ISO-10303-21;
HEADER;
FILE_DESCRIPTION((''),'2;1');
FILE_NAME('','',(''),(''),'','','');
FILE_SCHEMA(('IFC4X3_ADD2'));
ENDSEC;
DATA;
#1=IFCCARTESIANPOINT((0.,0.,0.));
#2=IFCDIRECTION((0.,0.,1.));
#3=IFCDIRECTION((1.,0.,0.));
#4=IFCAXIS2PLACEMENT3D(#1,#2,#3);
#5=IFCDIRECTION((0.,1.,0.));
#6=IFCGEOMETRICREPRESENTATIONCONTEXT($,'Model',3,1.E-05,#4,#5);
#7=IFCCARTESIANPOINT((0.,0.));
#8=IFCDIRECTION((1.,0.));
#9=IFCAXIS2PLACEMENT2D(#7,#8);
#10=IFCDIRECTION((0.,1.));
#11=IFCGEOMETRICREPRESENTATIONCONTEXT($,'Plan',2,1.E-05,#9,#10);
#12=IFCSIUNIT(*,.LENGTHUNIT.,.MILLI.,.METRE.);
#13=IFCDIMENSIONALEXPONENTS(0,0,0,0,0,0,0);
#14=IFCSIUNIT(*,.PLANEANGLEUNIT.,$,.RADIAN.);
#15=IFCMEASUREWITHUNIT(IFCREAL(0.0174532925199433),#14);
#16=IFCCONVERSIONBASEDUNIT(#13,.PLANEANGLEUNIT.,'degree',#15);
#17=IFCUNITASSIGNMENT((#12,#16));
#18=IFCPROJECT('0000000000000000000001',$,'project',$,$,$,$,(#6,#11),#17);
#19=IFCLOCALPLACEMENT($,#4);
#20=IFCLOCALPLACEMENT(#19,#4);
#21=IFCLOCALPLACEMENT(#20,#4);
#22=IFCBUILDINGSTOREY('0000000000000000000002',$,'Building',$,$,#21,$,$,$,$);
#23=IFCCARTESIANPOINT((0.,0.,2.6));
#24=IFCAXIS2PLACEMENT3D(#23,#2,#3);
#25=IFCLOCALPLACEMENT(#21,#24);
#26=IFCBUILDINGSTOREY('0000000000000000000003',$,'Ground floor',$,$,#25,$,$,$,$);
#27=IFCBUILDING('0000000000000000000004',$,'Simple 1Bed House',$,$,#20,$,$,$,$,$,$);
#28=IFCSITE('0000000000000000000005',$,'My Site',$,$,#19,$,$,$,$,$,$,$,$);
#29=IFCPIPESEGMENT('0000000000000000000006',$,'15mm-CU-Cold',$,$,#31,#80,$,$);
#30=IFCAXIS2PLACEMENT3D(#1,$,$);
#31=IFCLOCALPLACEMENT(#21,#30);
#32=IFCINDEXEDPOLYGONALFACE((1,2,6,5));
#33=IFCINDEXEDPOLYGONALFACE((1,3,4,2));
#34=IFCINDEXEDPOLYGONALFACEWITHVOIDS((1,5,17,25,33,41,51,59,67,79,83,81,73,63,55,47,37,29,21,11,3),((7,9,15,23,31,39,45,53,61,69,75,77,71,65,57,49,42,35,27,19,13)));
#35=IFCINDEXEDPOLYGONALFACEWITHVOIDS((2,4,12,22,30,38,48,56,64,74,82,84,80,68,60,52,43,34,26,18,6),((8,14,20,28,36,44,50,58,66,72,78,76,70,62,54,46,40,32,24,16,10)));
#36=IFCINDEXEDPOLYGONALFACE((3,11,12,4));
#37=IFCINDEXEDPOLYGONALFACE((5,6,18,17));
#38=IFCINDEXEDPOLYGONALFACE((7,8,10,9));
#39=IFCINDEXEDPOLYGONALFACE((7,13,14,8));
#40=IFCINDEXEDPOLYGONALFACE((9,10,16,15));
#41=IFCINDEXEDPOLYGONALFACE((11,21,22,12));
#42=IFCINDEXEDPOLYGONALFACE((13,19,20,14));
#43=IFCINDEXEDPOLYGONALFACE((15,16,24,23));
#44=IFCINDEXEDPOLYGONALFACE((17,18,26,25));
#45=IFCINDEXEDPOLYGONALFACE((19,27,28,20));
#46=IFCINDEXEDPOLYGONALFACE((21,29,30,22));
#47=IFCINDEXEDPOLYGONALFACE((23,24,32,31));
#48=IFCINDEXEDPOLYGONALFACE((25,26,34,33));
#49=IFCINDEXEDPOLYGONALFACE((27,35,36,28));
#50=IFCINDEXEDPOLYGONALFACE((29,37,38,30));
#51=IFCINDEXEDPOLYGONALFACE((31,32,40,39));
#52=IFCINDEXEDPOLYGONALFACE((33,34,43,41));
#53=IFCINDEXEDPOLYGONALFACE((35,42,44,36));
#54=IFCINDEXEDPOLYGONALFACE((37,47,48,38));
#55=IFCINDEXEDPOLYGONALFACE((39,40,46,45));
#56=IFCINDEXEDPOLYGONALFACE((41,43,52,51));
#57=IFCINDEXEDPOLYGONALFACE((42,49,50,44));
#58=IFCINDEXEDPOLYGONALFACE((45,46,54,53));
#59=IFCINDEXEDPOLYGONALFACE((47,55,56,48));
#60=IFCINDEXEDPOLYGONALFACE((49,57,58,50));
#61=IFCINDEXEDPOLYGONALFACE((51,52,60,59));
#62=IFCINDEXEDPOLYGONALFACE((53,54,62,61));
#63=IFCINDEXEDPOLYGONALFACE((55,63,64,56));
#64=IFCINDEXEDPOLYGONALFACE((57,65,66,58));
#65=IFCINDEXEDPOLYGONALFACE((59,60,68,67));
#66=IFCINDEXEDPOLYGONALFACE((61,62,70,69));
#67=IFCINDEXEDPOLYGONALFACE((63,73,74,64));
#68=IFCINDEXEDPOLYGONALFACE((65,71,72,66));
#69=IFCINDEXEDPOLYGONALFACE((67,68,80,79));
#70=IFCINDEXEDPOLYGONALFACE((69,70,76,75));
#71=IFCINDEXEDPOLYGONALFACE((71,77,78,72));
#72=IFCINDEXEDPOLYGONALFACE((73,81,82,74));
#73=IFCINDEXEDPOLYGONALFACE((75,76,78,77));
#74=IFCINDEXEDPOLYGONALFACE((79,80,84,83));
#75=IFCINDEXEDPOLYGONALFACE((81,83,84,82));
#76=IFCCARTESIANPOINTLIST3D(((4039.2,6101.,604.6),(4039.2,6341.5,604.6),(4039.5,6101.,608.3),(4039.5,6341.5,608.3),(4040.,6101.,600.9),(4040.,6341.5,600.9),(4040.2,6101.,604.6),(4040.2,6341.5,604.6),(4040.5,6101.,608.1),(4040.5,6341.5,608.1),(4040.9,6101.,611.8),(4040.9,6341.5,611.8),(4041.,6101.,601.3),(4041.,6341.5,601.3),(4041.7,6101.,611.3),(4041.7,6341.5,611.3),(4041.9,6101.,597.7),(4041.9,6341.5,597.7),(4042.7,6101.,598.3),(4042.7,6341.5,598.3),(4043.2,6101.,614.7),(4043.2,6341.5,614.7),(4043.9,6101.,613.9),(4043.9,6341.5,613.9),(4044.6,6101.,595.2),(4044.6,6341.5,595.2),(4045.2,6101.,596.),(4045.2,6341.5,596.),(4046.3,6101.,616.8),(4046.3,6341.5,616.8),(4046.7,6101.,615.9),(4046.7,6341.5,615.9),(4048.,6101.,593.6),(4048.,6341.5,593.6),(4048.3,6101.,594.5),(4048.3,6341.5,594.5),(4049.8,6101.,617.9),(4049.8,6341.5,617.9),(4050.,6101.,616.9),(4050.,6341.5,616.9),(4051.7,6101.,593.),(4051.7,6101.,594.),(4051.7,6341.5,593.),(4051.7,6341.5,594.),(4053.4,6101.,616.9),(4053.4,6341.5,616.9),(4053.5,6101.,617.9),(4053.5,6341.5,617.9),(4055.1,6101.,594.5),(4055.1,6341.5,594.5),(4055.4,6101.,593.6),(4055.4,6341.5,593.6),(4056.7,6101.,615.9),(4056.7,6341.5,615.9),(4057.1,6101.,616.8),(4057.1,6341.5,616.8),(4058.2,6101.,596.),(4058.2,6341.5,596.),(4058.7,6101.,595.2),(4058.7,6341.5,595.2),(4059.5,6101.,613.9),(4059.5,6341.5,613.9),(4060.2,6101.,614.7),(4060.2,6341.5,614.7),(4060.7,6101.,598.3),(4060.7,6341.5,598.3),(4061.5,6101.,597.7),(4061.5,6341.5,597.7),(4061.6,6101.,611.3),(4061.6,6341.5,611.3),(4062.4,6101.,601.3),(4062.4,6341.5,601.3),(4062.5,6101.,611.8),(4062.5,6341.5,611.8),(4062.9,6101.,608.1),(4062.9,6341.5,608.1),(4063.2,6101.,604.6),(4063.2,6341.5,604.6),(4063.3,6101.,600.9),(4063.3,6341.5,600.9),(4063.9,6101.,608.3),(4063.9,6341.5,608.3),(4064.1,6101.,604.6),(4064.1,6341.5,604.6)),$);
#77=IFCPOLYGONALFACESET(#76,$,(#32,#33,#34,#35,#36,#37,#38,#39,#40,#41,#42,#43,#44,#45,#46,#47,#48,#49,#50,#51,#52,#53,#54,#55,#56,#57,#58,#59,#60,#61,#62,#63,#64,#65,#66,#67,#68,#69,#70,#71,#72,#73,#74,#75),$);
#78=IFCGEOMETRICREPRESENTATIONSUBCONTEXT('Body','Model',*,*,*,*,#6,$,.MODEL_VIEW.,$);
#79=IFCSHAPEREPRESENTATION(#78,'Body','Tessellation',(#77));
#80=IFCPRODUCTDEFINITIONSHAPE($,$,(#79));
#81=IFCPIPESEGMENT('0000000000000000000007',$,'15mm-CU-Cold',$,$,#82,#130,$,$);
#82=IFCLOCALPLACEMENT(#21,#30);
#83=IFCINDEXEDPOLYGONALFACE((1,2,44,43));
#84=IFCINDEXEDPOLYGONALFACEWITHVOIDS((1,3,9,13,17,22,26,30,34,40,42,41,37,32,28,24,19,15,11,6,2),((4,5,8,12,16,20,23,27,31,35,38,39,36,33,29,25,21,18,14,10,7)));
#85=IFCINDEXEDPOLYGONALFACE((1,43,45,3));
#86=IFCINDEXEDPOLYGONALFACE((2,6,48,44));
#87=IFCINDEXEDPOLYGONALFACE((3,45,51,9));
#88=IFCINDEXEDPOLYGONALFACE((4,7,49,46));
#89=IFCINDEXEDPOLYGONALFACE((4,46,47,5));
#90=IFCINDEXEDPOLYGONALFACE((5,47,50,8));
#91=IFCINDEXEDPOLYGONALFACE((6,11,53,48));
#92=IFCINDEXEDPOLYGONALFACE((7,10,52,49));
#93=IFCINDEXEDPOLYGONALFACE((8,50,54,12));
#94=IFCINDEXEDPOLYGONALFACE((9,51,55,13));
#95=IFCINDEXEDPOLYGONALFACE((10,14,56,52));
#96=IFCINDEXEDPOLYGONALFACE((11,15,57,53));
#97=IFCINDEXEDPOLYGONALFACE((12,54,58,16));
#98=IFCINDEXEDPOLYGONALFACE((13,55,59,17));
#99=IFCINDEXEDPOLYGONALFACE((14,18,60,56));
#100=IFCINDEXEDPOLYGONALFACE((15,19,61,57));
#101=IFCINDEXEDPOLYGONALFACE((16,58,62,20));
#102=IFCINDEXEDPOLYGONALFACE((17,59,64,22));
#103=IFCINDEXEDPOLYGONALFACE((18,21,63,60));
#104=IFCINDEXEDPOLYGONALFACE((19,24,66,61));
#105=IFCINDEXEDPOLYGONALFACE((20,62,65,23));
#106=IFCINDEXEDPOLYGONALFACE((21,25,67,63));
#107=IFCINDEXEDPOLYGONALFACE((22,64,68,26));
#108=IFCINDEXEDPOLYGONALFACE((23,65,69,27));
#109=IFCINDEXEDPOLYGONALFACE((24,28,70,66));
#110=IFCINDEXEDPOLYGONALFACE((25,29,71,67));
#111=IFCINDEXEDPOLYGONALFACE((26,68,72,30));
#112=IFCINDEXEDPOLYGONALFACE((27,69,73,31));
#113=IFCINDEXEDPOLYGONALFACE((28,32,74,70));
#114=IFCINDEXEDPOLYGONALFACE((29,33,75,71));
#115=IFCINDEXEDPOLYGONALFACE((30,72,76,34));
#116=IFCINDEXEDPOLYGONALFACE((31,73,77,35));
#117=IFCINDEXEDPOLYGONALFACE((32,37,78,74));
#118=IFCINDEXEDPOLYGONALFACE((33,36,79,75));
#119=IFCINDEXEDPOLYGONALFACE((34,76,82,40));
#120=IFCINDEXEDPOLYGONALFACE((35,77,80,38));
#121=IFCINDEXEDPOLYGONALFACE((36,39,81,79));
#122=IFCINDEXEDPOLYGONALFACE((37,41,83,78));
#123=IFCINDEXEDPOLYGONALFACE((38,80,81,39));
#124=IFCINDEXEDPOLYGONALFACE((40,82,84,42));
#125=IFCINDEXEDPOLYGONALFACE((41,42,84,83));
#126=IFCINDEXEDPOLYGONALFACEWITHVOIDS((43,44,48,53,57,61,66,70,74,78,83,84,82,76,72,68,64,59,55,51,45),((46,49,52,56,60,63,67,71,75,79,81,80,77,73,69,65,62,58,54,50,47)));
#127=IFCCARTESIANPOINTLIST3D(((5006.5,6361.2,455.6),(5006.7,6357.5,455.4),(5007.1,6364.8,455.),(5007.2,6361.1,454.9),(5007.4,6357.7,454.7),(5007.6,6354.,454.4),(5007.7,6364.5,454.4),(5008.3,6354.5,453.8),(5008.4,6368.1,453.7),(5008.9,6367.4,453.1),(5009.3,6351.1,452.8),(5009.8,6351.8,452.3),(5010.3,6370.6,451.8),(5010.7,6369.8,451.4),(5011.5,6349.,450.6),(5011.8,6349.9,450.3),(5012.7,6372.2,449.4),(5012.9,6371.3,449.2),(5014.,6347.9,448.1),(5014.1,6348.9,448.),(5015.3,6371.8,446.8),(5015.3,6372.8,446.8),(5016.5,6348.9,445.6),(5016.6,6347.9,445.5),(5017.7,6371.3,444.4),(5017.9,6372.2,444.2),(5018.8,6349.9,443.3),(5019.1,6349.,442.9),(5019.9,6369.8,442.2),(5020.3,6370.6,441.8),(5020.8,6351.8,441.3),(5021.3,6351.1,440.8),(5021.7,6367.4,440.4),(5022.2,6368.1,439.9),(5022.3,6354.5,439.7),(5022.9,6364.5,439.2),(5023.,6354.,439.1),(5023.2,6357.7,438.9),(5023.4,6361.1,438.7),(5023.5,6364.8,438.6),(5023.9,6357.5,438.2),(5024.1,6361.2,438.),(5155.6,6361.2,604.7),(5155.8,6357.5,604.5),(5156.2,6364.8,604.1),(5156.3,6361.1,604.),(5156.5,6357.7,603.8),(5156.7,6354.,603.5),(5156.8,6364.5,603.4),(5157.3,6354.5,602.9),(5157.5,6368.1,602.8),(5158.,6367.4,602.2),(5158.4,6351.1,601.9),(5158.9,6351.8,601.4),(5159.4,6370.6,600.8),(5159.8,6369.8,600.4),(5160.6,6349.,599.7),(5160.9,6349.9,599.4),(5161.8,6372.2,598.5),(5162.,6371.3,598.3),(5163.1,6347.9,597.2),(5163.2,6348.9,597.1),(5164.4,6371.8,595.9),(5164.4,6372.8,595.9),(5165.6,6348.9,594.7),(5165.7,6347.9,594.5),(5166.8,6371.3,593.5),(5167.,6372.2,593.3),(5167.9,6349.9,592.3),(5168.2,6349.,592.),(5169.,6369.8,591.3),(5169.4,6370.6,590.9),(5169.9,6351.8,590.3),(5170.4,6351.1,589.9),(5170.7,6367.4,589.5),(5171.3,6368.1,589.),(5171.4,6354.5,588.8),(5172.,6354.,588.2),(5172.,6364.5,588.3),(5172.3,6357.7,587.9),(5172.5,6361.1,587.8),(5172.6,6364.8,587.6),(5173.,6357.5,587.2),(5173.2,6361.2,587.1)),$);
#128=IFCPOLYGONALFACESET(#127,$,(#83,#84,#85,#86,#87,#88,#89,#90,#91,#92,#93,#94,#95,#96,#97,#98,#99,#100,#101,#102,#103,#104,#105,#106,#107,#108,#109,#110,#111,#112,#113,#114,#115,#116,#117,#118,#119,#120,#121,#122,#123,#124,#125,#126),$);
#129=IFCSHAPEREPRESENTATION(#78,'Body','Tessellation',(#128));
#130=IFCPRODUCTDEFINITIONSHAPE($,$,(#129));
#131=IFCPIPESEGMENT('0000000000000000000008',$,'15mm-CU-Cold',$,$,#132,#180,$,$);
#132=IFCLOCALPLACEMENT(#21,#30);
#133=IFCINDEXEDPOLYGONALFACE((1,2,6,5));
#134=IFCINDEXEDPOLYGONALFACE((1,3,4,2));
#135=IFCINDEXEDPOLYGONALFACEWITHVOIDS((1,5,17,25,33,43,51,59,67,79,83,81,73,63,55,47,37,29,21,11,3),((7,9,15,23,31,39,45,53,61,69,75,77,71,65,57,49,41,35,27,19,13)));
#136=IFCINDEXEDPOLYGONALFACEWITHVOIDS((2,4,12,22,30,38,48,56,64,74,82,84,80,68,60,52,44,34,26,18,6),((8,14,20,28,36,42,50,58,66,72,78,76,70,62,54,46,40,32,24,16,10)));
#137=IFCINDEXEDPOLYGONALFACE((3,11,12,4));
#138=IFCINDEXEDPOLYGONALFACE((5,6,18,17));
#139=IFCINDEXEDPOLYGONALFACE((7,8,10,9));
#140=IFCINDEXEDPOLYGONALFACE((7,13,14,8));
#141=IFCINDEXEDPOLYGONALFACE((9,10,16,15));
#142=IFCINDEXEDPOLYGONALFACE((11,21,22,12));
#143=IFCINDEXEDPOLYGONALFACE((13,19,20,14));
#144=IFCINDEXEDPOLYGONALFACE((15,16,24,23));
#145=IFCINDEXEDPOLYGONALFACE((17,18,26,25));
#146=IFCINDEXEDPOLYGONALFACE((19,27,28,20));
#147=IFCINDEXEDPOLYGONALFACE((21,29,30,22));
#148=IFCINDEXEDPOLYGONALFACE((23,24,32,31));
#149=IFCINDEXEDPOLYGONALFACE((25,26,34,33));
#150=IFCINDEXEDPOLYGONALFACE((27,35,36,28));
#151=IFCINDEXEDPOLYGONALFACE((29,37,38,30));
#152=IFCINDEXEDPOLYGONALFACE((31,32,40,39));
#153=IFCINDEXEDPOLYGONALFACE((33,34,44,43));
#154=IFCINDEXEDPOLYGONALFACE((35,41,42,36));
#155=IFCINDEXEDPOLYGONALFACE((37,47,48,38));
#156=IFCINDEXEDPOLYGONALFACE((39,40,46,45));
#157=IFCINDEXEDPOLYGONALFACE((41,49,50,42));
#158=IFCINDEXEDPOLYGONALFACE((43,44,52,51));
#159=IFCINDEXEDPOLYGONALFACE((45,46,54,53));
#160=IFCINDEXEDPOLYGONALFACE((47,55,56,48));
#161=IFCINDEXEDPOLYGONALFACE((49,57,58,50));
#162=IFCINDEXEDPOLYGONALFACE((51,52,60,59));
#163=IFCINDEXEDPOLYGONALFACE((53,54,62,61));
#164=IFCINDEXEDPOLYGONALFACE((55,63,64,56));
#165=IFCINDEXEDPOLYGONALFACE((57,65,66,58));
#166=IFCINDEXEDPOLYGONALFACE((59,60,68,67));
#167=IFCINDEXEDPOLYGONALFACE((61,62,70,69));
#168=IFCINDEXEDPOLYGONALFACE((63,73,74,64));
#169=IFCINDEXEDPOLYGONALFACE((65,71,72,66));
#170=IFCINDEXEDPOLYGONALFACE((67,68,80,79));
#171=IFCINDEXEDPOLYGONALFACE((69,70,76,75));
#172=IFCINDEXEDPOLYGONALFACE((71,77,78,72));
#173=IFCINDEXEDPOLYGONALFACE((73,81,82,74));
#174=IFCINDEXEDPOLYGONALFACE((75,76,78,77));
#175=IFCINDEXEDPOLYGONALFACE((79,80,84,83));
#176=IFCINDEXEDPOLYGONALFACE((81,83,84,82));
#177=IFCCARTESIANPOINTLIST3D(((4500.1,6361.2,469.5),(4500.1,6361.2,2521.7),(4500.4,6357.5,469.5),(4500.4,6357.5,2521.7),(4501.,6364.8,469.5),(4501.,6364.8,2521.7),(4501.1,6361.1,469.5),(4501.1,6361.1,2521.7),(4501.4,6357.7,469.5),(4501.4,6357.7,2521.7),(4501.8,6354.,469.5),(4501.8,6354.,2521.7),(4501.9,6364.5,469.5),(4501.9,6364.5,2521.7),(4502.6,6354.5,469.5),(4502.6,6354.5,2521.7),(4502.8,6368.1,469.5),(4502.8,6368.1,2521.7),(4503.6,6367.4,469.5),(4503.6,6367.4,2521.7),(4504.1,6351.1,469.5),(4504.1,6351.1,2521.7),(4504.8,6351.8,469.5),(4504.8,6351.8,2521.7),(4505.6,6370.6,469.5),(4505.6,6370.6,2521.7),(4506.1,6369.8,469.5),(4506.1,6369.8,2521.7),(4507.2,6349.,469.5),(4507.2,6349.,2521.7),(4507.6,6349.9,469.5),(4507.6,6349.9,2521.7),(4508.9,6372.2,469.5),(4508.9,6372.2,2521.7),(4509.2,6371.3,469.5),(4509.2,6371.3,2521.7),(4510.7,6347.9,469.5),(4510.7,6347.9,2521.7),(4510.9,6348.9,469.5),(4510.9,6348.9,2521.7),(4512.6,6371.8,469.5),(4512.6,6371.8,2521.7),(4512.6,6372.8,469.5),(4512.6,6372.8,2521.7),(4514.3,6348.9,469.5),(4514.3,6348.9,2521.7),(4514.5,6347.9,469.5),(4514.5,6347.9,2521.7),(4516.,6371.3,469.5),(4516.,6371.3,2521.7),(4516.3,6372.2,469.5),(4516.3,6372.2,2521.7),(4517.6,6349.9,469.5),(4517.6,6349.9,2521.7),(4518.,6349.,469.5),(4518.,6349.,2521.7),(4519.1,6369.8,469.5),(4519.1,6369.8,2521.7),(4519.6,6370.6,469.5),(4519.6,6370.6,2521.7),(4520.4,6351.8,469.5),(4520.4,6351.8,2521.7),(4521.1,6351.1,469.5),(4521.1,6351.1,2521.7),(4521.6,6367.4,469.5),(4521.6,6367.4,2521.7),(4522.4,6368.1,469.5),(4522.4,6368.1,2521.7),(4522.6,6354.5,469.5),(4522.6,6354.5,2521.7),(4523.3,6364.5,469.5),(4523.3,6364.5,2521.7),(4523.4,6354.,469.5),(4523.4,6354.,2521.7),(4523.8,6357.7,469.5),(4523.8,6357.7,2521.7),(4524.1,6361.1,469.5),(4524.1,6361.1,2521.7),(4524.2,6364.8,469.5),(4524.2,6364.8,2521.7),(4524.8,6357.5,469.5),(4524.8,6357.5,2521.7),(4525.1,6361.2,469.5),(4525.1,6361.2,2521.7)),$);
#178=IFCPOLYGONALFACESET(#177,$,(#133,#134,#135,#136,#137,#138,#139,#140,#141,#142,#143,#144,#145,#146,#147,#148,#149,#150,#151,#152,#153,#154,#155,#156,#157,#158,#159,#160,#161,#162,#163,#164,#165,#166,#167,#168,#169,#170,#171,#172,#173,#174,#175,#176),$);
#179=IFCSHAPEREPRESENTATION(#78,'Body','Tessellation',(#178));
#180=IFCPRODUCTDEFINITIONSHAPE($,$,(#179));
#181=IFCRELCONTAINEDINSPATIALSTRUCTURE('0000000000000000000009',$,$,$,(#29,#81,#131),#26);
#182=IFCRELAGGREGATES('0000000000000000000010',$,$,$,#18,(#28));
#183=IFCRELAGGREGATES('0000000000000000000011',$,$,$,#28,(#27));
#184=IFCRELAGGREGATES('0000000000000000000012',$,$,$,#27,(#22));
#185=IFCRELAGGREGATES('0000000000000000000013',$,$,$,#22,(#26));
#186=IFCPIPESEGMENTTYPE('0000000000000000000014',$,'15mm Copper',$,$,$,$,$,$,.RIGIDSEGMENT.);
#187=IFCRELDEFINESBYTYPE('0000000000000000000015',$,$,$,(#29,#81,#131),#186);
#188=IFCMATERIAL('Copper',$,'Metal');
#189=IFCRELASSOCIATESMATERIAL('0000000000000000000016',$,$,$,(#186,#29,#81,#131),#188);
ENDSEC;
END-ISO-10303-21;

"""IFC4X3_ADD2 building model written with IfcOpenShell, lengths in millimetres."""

from ifc_helpers import new_model, entity, si_unit, converted_unit, direction, frame, origin_with_axes, origin_2d_with_axis, place, context, subcontext, project, spatial, hollow_circle, extrude, material, material_profile, profile_set, profile_usage, type_object, element, save


model = new_model("IFC4X3_ADD2")

# Units and contexts
model_context = context("Model", 3, precision=1e-05, world=origin_with_axes(), true_north=direction((0.0, 1.0, 0.0)))
plan_context = context("Plan", 2, precision=1e-05, world=origin_2d_with_axis(), true_north=direction((0.0, 1.0)))
body_context_1 = subcontext(model_context, "Body", "Model", "MODEL_VIEW")
ifc_project = project(units=[si_unit("LENGTHUNIT", "METRE", prefix="MILLI"), converted_unit("PLANEANGLEUNIT", "degree", entity("IfcReal", 0.0174532925199433), si_unit("PLANEANGLEUNIT", "RADIAN"), dimensions=[0, 0, 0, 0, 0, 0, 0])], contexts=[model_context, plan_context])

# Site, building, storeys
site_placement = place(None, origin_with_axes())
site = spatial("IfcSite", under=ifc_project, at=site_placement, Name="My Site")
building_placement = place(site_placement, origin_with_axes())
building = spatial("IfcBuilding", under=site, at=building_placement, Name="Simple 1Bed House")
storey_1_placement = place(building_placement, origin_with_axes())
storey_1 = spatial("IfcBuildingStorey", under=building, at=storey_1_placement, Name="Building")
storey_2_placement = place(storey_1_placement, frame((0.0, 0.0, 2.6), z_axis=(0.0, 0.0, 1.0), x_axis=(1.0, 0.0, 0.0)))
storey_2 = spatial("IfcBuildingStorey", under=storey_1, at=storey_2_placement, Name="Ground floor")

# Pipe segments
ifc_material_1 = material(Name="Copper", Category="Metal")
ifc_material_profile = material_profile(ifc_material_1, hollow_circle(Radius=12.5, WallThickness=1.0))
ifc_profile_set = profile_set([ifc_material_profile])
pipe_segment_type = type_object("IfcPipeSegmentType", Name="15mm Copper", PredefinedType="RIGIDSEGMENT", material=ifc_profile_set)
ifc_profile_usage_1 = profile_usage(ifc_profile_set, cardinal=5)
pipe_segment_1_placement = place(storey_2_placement, frame((4051.7, 6341.5, 602.9), z_axis=(0.0, -1.0, 0.0), x_axis=(0.0, 0.0, -1.0)))
element("IfcPipeSegment", 1, at=pipe_segment_1_placement, inside=storey_2, type_object=pipe_segment_type, material=ifc_profile_usage_1, Name="15mm-CU-Cold", context=body_context_1, shape_type="SweptSolid", body=[
    extrude(hollow_circle(Radius=12.5, WallThickness=1.0), origin_with_axes(), (0.0, 0.0, 1.0), 240.5),
])
ifc_profile_usage_2 = profile_usage(ifc_profile_set, cardinal=5)
pipe_segment_2_placement = place(storey_2_placement, frame((5164.4, 6360.3, 593.3), z_axis=(-0.707107, 0.0, -0.707107), x_axis=(0.0, 1.0, 0.0)))
element("IfcPipeSegment", 2, at=pipe_segment_2_placement, inside=storey_2, type_object=pipe_segment_type, material=ifc_profile_usage_2, Name="15mm-CU-Cold", context=body_context_1, shape_type="SweptSolid", body=[
    extrude(hollow_circle(Radius=12.5, WallThickness=1.0), origin_with_axes(), (0.0, 0.0, 1.0), 210.8),
])
ifc_profile_usage_3 = profile_usage(ifc_profile_set, cardinal=5)
pipe_segment_3_placement = place(storey_2_placement, frame((4512.6, 6360.3, 2519.1), z_axis=(0.0, 0.0, -1.0), x_axis=(0.0, 1.0, 0.0)))
element("IfcPipeSegment", 3, at=pipe_segment_3_placement, inside=storey_2, type_object=pipe_segment_type, material=ifc_profile_usage_3, Name="15mm-CU-Cold", context=body_context_1, shape_type="SweptSolid", body=[
    extrude(hollow_circle(Radius=12.5, WallThickness=1.0), origin_with_axes(), (0.0, 0.0, 1.0), 2052.2),
])

save(model, "model.ifc")
